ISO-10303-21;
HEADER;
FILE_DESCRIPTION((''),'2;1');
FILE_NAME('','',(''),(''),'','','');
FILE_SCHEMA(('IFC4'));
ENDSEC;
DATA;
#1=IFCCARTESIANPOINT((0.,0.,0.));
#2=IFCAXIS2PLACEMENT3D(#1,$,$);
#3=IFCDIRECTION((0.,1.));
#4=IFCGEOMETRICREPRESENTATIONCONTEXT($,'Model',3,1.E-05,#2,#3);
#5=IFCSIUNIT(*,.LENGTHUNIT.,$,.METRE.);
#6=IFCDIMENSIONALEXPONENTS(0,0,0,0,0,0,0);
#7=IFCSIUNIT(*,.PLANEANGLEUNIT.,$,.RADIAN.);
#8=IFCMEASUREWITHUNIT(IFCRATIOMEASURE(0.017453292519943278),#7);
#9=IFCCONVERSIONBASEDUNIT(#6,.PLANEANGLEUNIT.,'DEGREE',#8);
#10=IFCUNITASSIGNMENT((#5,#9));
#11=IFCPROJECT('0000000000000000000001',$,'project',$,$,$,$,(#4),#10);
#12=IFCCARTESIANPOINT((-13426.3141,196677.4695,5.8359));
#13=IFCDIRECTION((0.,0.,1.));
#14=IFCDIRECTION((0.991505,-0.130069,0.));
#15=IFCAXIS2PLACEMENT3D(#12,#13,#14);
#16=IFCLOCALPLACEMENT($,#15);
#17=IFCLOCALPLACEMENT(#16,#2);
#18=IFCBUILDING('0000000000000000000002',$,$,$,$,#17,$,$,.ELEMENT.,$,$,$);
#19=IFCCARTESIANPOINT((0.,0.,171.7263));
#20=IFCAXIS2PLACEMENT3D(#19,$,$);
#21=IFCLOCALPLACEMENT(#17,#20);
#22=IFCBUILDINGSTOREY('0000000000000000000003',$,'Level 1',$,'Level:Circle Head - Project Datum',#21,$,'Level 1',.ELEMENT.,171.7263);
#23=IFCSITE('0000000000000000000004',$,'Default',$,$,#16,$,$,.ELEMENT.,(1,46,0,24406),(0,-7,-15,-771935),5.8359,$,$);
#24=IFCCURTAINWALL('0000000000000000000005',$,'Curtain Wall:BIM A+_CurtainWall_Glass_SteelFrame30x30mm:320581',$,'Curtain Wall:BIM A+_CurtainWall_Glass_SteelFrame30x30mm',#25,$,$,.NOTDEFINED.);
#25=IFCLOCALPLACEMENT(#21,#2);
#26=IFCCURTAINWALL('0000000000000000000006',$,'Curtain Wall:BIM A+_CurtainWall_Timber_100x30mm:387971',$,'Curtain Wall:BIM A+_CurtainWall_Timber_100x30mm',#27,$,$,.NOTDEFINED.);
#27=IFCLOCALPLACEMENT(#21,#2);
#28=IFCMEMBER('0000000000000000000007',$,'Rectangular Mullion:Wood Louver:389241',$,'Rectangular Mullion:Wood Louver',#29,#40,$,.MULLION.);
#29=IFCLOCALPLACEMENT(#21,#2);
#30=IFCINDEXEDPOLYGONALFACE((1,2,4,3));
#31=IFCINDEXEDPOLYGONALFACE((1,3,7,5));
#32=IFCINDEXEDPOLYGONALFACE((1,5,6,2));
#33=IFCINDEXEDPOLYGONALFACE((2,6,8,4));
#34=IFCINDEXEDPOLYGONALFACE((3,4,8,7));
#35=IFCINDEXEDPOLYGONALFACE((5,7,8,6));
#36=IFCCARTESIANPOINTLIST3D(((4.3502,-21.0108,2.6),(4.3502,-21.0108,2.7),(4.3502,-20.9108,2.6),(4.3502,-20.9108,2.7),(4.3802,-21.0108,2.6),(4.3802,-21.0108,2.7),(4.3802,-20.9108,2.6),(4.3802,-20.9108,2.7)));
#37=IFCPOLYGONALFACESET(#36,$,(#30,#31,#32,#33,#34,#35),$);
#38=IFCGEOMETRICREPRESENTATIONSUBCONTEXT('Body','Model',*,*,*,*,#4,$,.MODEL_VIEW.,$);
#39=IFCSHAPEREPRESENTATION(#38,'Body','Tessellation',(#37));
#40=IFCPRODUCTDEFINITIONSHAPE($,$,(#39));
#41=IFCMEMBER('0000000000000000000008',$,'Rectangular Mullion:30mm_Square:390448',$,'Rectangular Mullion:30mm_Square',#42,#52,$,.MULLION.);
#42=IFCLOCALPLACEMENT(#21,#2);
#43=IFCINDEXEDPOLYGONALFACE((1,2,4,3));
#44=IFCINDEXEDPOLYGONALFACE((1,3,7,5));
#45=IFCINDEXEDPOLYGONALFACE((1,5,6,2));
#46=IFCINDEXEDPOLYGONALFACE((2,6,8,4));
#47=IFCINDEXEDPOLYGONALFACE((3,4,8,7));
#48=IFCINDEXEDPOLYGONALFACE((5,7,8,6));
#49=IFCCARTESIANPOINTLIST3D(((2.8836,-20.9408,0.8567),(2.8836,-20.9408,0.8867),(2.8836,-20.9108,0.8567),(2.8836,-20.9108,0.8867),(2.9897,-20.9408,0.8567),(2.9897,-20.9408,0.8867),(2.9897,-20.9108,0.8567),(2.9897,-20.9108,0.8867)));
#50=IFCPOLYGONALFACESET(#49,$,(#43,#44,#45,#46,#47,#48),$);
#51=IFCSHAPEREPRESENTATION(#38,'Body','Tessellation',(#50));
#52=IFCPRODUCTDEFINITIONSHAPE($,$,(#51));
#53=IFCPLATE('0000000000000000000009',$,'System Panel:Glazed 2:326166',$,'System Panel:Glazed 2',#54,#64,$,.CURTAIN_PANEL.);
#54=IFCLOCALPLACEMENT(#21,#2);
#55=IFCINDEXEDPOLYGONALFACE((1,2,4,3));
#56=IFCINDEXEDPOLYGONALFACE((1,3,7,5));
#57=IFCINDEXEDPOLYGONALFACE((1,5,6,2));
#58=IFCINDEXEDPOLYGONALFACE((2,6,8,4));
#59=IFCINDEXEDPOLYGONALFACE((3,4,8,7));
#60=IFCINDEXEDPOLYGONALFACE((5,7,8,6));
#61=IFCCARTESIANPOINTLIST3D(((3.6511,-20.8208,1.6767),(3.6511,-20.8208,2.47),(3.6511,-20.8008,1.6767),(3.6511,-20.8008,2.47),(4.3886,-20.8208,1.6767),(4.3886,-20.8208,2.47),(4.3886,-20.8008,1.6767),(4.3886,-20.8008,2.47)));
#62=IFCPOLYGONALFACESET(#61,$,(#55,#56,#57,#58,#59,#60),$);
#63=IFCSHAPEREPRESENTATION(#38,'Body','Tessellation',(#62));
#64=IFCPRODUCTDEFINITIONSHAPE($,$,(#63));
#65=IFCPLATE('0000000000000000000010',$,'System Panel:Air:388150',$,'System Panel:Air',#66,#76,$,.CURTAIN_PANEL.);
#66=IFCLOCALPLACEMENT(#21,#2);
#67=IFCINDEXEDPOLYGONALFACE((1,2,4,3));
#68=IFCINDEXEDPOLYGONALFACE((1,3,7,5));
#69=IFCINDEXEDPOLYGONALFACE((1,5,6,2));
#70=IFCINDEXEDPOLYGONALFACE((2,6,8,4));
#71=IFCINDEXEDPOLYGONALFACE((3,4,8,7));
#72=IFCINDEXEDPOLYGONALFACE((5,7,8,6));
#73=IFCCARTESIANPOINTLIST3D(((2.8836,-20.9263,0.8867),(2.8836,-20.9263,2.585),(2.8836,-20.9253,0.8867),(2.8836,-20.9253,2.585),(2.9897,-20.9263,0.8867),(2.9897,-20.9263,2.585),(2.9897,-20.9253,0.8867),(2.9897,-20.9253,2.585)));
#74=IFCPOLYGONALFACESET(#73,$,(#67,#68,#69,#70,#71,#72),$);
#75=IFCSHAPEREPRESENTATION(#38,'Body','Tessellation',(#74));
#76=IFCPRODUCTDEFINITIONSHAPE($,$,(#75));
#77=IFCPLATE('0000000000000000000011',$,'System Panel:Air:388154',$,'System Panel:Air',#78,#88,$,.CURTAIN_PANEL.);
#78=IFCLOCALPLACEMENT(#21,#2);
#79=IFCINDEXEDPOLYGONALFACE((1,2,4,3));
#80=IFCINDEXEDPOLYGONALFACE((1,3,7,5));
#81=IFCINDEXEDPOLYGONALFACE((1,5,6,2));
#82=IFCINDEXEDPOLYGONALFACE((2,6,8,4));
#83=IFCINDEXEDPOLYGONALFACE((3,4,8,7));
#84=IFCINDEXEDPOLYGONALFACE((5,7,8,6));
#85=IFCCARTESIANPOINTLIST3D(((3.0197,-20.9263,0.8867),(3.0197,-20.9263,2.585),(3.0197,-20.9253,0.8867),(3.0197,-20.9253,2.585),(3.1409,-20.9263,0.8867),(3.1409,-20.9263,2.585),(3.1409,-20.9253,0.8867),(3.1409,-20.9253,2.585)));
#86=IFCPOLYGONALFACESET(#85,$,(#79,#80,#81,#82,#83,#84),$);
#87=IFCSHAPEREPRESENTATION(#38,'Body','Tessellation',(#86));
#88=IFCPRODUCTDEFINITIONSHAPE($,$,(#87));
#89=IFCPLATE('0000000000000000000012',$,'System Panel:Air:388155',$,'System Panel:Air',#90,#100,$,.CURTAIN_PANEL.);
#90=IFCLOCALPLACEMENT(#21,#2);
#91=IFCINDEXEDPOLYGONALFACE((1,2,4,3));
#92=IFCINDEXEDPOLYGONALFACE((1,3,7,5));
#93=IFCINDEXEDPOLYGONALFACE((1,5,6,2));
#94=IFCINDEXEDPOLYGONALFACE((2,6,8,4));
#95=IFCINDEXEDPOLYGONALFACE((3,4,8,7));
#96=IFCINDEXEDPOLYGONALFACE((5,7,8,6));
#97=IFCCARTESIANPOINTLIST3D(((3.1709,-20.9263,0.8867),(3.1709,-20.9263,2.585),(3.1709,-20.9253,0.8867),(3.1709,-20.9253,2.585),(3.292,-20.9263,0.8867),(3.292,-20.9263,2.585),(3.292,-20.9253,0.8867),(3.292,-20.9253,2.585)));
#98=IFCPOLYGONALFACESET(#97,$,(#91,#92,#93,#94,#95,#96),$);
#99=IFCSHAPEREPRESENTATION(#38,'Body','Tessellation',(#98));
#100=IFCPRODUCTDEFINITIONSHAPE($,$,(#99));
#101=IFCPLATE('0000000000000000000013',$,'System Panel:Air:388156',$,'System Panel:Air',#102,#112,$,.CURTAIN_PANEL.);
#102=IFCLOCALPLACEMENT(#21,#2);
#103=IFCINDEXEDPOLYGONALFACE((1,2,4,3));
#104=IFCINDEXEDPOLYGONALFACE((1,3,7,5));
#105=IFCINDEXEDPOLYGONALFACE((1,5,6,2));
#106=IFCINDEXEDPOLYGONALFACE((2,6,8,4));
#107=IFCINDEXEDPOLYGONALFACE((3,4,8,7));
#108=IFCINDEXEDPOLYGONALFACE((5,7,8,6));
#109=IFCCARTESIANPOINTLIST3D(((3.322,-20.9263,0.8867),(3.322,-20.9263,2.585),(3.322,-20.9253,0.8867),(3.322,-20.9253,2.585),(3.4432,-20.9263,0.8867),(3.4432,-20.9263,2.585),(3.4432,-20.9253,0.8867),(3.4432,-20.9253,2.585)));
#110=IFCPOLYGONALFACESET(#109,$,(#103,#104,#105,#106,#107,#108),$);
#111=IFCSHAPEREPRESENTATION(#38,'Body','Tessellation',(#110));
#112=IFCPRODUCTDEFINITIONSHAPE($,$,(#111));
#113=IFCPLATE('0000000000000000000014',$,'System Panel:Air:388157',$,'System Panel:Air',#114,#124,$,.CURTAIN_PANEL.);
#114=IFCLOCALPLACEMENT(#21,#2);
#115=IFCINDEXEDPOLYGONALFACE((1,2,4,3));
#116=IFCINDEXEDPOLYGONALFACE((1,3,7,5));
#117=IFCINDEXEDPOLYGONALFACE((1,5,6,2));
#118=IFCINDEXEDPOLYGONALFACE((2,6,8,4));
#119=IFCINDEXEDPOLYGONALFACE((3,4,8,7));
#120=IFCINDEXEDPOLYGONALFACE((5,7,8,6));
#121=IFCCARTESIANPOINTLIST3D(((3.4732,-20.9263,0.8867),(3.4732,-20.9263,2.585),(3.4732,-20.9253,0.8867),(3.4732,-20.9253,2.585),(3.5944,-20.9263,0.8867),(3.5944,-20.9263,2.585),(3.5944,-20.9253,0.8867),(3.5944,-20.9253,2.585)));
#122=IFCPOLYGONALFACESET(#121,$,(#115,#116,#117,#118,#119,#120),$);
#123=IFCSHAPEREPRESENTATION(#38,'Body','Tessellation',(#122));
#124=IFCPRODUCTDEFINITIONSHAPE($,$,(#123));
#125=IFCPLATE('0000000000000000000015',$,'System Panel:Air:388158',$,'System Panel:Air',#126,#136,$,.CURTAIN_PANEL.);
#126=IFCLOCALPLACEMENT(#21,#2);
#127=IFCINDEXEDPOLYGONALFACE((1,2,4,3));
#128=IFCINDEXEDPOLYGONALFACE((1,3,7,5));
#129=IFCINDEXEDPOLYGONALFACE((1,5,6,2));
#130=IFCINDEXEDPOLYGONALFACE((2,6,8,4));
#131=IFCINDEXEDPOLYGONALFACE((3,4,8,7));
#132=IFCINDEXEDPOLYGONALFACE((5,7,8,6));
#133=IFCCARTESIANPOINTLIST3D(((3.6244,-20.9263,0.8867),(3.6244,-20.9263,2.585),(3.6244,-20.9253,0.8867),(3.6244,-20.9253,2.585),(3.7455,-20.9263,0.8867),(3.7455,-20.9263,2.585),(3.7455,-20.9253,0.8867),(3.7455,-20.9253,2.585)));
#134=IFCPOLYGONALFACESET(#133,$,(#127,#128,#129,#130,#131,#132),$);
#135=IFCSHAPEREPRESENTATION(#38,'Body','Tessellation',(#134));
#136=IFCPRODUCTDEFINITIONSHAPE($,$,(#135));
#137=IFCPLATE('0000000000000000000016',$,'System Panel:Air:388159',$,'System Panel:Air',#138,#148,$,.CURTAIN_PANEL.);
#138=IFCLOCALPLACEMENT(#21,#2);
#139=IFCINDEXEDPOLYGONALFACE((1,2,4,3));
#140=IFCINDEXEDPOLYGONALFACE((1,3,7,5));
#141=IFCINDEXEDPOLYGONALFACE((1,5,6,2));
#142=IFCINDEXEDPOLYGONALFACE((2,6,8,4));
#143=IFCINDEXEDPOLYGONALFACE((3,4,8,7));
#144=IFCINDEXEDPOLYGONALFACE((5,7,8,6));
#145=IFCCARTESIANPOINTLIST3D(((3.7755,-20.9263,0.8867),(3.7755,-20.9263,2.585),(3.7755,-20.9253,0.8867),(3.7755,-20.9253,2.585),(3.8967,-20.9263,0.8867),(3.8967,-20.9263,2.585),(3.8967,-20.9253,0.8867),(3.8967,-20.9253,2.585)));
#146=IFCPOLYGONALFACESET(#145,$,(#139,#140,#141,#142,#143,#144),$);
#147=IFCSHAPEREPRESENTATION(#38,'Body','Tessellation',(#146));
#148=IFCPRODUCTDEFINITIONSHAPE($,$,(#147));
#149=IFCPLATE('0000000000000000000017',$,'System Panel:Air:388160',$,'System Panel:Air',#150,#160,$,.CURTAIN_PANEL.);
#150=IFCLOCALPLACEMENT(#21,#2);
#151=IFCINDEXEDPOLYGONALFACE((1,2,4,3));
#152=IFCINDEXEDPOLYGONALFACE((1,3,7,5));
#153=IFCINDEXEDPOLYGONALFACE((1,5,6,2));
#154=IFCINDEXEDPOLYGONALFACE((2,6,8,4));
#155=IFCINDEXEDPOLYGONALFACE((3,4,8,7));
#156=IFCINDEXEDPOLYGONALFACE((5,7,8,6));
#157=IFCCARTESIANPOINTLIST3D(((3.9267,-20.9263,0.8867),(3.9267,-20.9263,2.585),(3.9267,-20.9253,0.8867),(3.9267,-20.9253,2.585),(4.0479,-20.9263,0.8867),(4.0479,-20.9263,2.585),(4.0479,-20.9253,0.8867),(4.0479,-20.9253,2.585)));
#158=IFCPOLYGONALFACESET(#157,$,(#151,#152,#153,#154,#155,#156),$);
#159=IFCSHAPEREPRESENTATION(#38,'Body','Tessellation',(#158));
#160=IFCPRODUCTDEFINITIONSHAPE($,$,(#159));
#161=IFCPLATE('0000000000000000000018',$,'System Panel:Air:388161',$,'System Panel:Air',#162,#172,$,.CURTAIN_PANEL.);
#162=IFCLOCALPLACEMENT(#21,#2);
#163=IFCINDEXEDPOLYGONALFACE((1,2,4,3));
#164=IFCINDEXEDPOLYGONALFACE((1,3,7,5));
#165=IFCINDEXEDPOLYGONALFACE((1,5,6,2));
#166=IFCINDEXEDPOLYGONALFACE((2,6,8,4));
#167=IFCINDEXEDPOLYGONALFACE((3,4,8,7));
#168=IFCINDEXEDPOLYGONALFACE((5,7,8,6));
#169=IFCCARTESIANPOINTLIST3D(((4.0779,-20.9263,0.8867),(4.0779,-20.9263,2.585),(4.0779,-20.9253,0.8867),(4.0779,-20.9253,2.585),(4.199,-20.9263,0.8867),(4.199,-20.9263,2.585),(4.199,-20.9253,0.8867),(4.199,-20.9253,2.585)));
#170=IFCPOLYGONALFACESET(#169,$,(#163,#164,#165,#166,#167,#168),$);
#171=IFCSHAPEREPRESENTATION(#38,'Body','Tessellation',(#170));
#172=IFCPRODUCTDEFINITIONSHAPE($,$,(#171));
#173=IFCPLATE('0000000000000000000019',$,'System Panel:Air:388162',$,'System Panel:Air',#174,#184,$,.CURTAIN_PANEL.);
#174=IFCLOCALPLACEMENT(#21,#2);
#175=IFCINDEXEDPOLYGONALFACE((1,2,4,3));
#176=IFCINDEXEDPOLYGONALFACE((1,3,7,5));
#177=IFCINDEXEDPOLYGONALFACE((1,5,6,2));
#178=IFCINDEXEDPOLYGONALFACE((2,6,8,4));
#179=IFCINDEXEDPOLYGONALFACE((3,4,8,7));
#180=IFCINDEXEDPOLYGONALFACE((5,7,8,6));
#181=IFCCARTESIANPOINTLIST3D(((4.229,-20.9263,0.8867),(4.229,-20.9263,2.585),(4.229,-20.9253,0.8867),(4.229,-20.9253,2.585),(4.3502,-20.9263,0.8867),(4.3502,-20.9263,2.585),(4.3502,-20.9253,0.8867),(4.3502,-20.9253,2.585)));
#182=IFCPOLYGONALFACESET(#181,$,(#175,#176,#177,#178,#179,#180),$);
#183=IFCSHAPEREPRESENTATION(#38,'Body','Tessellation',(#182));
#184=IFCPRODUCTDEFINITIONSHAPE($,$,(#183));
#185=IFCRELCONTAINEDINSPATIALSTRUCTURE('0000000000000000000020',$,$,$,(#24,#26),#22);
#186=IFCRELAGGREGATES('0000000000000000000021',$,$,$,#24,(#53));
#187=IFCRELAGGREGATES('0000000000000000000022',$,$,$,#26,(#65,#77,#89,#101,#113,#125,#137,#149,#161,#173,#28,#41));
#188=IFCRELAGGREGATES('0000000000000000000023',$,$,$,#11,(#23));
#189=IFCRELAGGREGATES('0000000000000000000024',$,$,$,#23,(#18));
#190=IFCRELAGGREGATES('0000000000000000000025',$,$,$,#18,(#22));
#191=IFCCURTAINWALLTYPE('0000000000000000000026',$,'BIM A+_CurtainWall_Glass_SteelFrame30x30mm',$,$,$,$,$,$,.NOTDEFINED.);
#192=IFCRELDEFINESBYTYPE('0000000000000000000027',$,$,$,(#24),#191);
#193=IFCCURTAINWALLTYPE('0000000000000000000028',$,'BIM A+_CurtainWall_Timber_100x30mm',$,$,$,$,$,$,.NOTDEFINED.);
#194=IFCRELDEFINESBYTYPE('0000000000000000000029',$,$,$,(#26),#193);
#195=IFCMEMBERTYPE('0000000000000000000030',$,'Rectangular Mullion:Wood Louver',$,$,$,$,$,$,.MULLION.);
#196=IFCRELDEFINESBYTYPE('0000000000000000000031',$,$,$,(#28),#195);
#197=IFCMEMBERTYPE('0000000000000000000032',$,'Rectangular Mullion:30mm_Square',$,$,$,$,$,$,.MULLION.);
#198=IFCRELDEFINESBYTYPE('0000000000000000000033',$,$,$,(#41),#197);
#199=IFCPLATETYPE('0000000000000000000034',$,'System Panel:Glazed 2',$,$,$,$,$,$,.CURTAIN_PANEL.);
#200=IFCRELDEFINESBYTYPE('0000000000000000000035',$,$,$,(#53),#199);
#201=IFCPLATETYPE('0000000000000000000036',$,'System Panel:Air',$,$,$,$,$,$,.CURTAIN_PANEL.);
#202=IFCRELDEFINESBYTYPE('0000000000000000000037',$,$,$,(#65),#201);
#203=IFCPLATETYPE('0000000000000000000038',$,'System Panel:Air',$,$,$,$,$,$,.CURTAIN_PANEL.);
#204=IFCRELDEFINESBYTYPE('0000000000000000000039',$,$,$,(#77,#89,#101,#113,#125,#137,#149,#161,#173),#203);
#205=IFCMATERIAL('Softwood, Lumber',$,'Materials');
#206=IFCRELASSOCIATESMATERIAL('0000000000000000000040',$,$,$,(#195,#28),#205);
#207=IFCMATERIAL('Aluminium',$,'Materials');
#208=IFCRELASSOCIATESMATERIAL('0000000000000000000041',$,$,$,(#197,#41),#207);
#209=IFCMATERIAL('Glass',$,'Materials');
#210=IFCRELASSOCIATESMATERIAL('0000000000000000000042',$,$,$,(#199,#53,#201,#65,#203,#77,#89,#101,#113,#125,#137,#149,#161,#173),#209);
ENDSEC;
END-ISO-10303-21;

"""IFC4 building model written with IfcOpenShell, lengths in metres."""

from ifc_helpers import new_model, entity, si_unit, converted_unit, direction, frame, origin, place, context, subcontext, project, spatial, indexed_curve, outline, extrude, source, transform, mapped, material, type_object, type_shapes, element, aggregate, save


model = new_model("IFC4")

# Units and contexts
model_context = context("Model", 3, precision=1e-05, world=origin(), true_north=direction((0.0, 1.0)))
body_context = subcontext(model_context, "Body", "Model", "MODEL_VIEW")
ifc_project = project(units=[si_unit("LENGTHUNIT", "METRE"), converted_unit("PLANEANGLEUNIT", "DEGREE", entity("IfcRatioMeasure", 0.017453292519943278), si_unit("PLANEANGLEUNIT", "RADIAN"), dimensions=[0, 0, 0, 0, 0, 0, 0])], contexts=[model_context])

# Site, building, storey
site_placement = place(None, frame((-13426.3141, 196677.4695, 5.8359), z_axis=(0.0, 0.0, 1.0), x_axis=(0.991505, -0.130069, 0.0)))
site = spatial("IfcSite", under=ifc_project, at=site_placement, Name="Default", CompositionType="ELEMENT", RefLatitude=(1, 46, 0, 24406), RefLongitude=(0, -7, -15, -771935), RefElevation=5.8359)
building_placement = place(site_placement, origin())
building = spatial("IfcBuilding", under=site, at=building_placement, CompositionType="ELEMENT")
storey_placement = place(building_placement, frame((0.0, 0.0, 171.7263)))
storey = spatial("IfcBuildingStorey", under=building, at=storey_placement, Name="Level 1", ObjectType="Level:Circle Head - Project Datum", LongName="Level 1", CompositionType="ELEMENT", Elevation=171.7263)

# Curtain walls, members
curtain_wall_type_1 = type_object("IfcCurtainWallType", Name="BIM A+_CurtainWall_Glass_SteelFrame30x30mm", PredefinedType="NOTDEFINED")
curtain_wall_1_placement = place(storey_placement, frame((0.0, 0.0, -171.7263)))
curtain_wall_1 = element("IfcCurtainWall", 1, at=curtain_wall_1_placement, inside=storey, type_object=curtain_wall_type_1, Name="Curtain Wall:BIM A+_CurtainWall_Glass_SteelFrame30x30mm:320581", ObjectType="Curtain Wall:BIM A+_CurtainWall_Glass_SteelFrame30x30mm", PredefinedType="NOTDEFINED")
ifc_material_1 = material(Name="Aluminium", Category="Materials")
curtain_wall_type_2 = type_object("IfcCurtainWallType", Name="BIM A+_CurtainWall_Timber_100x30mm", PredefinedType="NOTDEFINED")
curtain_wall_2_placement = place(storey_placement, frame((0.0, 0.0, -171.7263)))
curtain_wall_2 = element("IfcCurtainWall", 2, at=curtain_wall_2_placement, inside=storey, type_object=curtain_wall_type_2, Name="Curtain Wall:BIM A+_CurtainWall_Timber_100x30mm:387971", ObjectType="Curtain Wall:BIM A+_CurtainWall_Timber_100x30mm", PredefinedType="NOTDEFINED")
ifc_material_2 = material(Name="Softwood, Lumber", Category="Materials")
member_type_1 = type_object("IfcMemberType", Name="Rectangular Mullion:Wood Louver", PredefinedType="MULLION", material=ifc_material_2)
shared_shape_1 = source(origin(), body_context, "Body", "SweptSolid", [
    extrude(outline(indexed_curve([(-0.05, -0.015), (0.05, -0.015), (0.05, 0.015), (-0.05, 0.015), (-0.05, -0.015)], self_intersect=False)), frame((0.0, 0.035, -0.1), z_axis=(0.0, 0.0, 1.0), x_axis=(0.0, -1.0, 0.0)), (0.0, 0.0, 1.0), 0.1),
])
type_shapes(member_type_1, [shared_shape_1])
member_1_placement = place(curtain_wall_2_placement, frame((4.3652, -20.9258, 174.3263), z_axis=(0.0, 0.0, -1.0), x_axis=(1.0, 0.0, 0.0)))
member_1 = element("IfcMember", 3, at=member_1_placement, type_object=member_type_1, material=ifc_material_2, Name="Rectangular Mullion:Wood Louver:389241", ObjectType="Rectangular Mullion:Wood Louver", PredefinedType="MULLION", context=body_context, shape_type="MappedRepresentation", body=[
    mapped(shared_shape_1, transform((0.0, 0.0, 0.0), scale=1.0)),
])
member_type_2 = type_object("IfcMemberType", Name="Rectangular Mullion:30mm_Square", PredefinedType="MULLION", material=ifc_material_1)
shared_shape_2 = source(origin(), body_context, "Body", "SweptSolid", [
    extrude(outline(indexed_curve([(-0.015, -0.015), (0.015, -0.015), (0.015, 0.015), (-0.015, 0.015), (-0.015, -0.015)], self_intersect=False)), frame((0.0, 0.0, -0.1062), z_axis=(0.0, 0.0, 1.0), x_axis=(0.0, -1.0, 0.0)), (0.0, 0.0, 1.0), 0.1062),
])
type_shapes(member_type_2, [shared_shape_2])
member_2_placement = place(curtain_wall_2_placement, frame((2.9897, -20.9258, 172.598), z_axis=(1.0, 0.0, 0.0), x_axis=(0.0, 0.0, 1.0)))
member_2 = element("IfcMember", 4, at=member_2_placement, type_object=member_type_2, material=ifc_material_1, Name="Rectangular Mullion:30mm_Square:390448", ObjectType="Rectangular Mullion:30mm_Square", PredefinedType="MULLION", context=body_context, shape_type="MappedRepresentation", body=[
    mapped(shared_shape_2, transform((0.0, 0.0, 0.0), scale=1.0)),
])

# Plates
ifc_material_3 = material(Name="Glass", Category="Materials")
plate_type_1 = type_object("IfcPlateType", Name="System Panel:Glazed 2", PredefinedType="CURTAIN_PANEL", material=ifc_material_3)
shared_shape_3 = source(origin(), body_context, "Body", "SweptSolid", [
    extrude(outline(indexed_curve([(-0.01, -0.3688), (0.01, -0.3688), (0.01, 0.3688), (-0.01, 0.3688), (-0.01, -0.3688)], self_intersect=False)), frame((0.0, 0.0, 0.0), z_axis=(0.0, 0.0, 1.0), x_axis=(0.0, 1.0, 0.0)), (0.0, 0.0, 1.0), 0.7933),
])
type_shapes(plate_type_1, [shared_shape_3])
plate_1_placement = place(curtain_wall_1_placement, frame((4.0198, -20.8108, 173.4029)))
plate_1 = element("IfcPlate", 5, at=plate_1_placement, type_object=plate_type_1, material=ifc_material_3, Name="System Panel:Glazed 2:326166", ObjectType="System Panel:Glazed 2", PredefinedType="CURTAIN_PANEL", context=body_context, shape_type="MappedRepresentation", body=[
    mapped(shared_shape_3, transform((0.0, 0.0, 0.0), scale=1.0)),
])
aggregate(curtain_wall_1, [plate_1])
plate_type_2 = type_object("IfcPlateType", Name="System Panel:Air", PredefinedType="CURTAIN_PANEL", material=ifc_material_3)
shared_shape_4 = source(origin(), body_context, "Body", "SweptSolid", [
    extrude(outline(indexed_curve([(-0.0005, -0.0531), (0.0005, -0.0531), (0.0005, 0.0531), (-0.0005, 0.0531), (-0.0005, -0.0531)], self_intersect=False)), frame((0.0, 0.0, 0.0), z_axis=(0.0, 0.0, 1.0), x_axis=(0.0, 1.0, 0.0)), (0.0, 0.0, 1.0), 1.6983),
])
type_shapes(plate_type_2, [shared_shape_4])
plate_2_placement = place(curtain_wall_2_placement, frame((2.9366, -20.9258, 172.613)))
plate_2 = element("IfcPlate", 6, at=plate_2_placement, type_object=plate_type_2, material=ifc_material_3, Name="System Panel:Air:388150", ObjectType="System Panel:Air", PredefinedType="CURTAIN_PANEL", context=body_context, shape_type="MappedRepresentation", body=[
    mapped(shared_shape_4, transform((0.0, 0.0, 0.0), scale=1.0)),
])
plate_type_3 = type_object("IfcPlateType", Name="System Panel:Air", PredefinedType="CURTAIN_PANEL", material=ifc_material_3)
shared_shape_5 = source(origin(), body_context, "Body", "SweptSolid", [
    extrude(outline(indexed_curve([(-0.0005, -0.0606), (0.0005, -0.0606), (0.0005, 0.0606), (-0.0005, 0.0606), (-0.0005, -0.0606)], self_intersect=False)), frame((0.0, 0.0, 0.0), z_axis=(0.0, 0.0, 1.0), x_axis=(0.0, 1.0, 0.0)), (0.0, 0.0, 1.0), 1.6983),
])
type_shapes(plate_type_3, [shared_shape_5])
plate_3_placement = place(curtain_wall_2_placement, frame((3.0803, -20.9258, 172.613)))
plate_3 = element("IfcPlate", 7, at=plate_3_placement, type_object=plate_type_3, material=ifc_material_3, Name="System Panel:Air:388154", ObjectType="System Panel:Air", PredefinedType="CURTAIN_PANEL", context=body_context, shape_type="MappedRepresentation", body=[
    mapped(shared_shape_5, transform((0.0, 0.0, 0.0), scale=1.0)),
])
plate_4_placement = place(curtain_wall_2_placement, frame((3.2315, -20.9258, 172.613)))
plate_4 = element("IfcPlate", 8, at=plate_4_placement, type_object=plate_type_3, material=ifc_material_3, Name="System Panel:Air:388155", ObjectType="System Panel:Air", PredefinedType="CURTAIN_PANEL", context=body_context, shape_type="MappedRepresentation", body=[
    mapped(shared_shape_5, transform((0.0, 0.0, 0.0), scale=1.0)),
])
plate_5_placement = place(curtain_wall_2_placement, frame((3.3826, -20.9258, 172.613)))
plate_5 = element("IfcPlate", 9, at=plate_5_placement, type_object=plate_type_3, material=ifc_material_3, Name="System Panel:Air:388156", ObjectType="System Panel:Air", PredefinedType="CURTAIN_PANEL", context=body_context, shape_type="MappedRepresentation", body=[
    mapped(shared_shape_5, transform((0.0, 0.0, 0.0), scale=1.0)),
])
plate_6_placement = place(curtain_wall_2_placement, frame((3.5338, -20.9258, 172.613)))
plate_6 = element("IfcPlate", 10, at=plate_6_placement, type_object=plate_type_3, material=ifc_material_3, Name="System Panel:Air:388157", ObjectType="System Panel:Air", PredefinedType="CURTAIN_PANEL", context=body_context, shape_type="MappedRepresentation", body=[
    mapped(shared_shape_5, transform((0.0, 0.0, 0.0), scale=1.0)),
])
plate_7_placement = place(curtain_wall_2_placement, frame((3.685, -20.9258, 172.613)))
plate_7 = element("IfcPlate", 11, at=plate_7_placement, type_object=plate_type_3, material=ifc_material_3, Name="System Panel:Air:388158", ObjectType="System Panel:Air", PredefinedType="CURTAIN_PANEL", context=body_context, shape_type="MappedRepresentation", body=[
    mapped(shared_shape_5, transform((0.0, 0.0, 0.0), scale=1.0)),
])
plate_8_placement = place(curtain_wall_2_placement, frame((3.8361, -20.9258, 172.613)))
plate_8 = element("IfcPlate", 12, at=plate_8_placement, type_object=plate_type_3, material=ifc_material_3, Name="System Panel:Air:388159", ObjectType="System Panel:Air", PredefinedType="CURTAIN_PANEL", context=body_context, shape_type="MappedRepresentation", body=[
    mapped(shared_shape_5, transform((0.0, 0.0, 0.0), scale=1.0)),
])
plate_9_placement = place(curtain_wall_2_placement, frame((3.9873, -20.9258, 172.613)))
plate_9 = element("IfcPlate", 13, at=plate_9_placement, type_object=plate_type_3, material=ifc_material_3, Name="System Panel:Air:388160", ObjectType="System Panel:Air", PredefinedType="CURTAIN_PANEL", context=body_context, shape_type="MappedRepresentation", body=[
    mapped(shared_shape_5, transform((0.0, 0.0, 0.0), scale=1.0)),
])
plate_10_placement = place(curtain_wall_2_placement, frame((4.1384, -20.9258, 172.613)))
plate_10 = element("IfcPlate", 14, at=plate_10_placement, type_object=plate_type_3, material=ifc_material_3, Name="System Panel:Air:388161", ObjectType="System Panel:Air", PredefinedType="CURTAIN_PANEL", context=body_context, shape_type="MappedRepresentation", body=[
    mapped(shared_shape_5, transform((0.0, 0.0, 0.0), scale=1.0)),
])
plate_11_placement = place(curtain_wall_2_placement, frame((4.2896, -20.9258, 172.613)))
plate_11 = element("IfcPlate", 15, at=plate_11_placement, type_object=plate_type_3, material=ifc_material_3, Name="System Panel:Air:388162", ObjectType="System Panel:Air", PredefinedType="CURTAIN_PANEL", context=body_context, shape_type="MappedRepresentation", body=[
    mapped(shared_shape_5, transform((0.0, 0.0, 0.0), scale=1.0)),
])
aggregate(curtain_wall_2, [plate_2, plate_3, plate_4, plate_5, plate_6, plate_7, plate_8, plate_9, plate_10, plate_11, member_1, member_2])

save(model, "model.ifc")
